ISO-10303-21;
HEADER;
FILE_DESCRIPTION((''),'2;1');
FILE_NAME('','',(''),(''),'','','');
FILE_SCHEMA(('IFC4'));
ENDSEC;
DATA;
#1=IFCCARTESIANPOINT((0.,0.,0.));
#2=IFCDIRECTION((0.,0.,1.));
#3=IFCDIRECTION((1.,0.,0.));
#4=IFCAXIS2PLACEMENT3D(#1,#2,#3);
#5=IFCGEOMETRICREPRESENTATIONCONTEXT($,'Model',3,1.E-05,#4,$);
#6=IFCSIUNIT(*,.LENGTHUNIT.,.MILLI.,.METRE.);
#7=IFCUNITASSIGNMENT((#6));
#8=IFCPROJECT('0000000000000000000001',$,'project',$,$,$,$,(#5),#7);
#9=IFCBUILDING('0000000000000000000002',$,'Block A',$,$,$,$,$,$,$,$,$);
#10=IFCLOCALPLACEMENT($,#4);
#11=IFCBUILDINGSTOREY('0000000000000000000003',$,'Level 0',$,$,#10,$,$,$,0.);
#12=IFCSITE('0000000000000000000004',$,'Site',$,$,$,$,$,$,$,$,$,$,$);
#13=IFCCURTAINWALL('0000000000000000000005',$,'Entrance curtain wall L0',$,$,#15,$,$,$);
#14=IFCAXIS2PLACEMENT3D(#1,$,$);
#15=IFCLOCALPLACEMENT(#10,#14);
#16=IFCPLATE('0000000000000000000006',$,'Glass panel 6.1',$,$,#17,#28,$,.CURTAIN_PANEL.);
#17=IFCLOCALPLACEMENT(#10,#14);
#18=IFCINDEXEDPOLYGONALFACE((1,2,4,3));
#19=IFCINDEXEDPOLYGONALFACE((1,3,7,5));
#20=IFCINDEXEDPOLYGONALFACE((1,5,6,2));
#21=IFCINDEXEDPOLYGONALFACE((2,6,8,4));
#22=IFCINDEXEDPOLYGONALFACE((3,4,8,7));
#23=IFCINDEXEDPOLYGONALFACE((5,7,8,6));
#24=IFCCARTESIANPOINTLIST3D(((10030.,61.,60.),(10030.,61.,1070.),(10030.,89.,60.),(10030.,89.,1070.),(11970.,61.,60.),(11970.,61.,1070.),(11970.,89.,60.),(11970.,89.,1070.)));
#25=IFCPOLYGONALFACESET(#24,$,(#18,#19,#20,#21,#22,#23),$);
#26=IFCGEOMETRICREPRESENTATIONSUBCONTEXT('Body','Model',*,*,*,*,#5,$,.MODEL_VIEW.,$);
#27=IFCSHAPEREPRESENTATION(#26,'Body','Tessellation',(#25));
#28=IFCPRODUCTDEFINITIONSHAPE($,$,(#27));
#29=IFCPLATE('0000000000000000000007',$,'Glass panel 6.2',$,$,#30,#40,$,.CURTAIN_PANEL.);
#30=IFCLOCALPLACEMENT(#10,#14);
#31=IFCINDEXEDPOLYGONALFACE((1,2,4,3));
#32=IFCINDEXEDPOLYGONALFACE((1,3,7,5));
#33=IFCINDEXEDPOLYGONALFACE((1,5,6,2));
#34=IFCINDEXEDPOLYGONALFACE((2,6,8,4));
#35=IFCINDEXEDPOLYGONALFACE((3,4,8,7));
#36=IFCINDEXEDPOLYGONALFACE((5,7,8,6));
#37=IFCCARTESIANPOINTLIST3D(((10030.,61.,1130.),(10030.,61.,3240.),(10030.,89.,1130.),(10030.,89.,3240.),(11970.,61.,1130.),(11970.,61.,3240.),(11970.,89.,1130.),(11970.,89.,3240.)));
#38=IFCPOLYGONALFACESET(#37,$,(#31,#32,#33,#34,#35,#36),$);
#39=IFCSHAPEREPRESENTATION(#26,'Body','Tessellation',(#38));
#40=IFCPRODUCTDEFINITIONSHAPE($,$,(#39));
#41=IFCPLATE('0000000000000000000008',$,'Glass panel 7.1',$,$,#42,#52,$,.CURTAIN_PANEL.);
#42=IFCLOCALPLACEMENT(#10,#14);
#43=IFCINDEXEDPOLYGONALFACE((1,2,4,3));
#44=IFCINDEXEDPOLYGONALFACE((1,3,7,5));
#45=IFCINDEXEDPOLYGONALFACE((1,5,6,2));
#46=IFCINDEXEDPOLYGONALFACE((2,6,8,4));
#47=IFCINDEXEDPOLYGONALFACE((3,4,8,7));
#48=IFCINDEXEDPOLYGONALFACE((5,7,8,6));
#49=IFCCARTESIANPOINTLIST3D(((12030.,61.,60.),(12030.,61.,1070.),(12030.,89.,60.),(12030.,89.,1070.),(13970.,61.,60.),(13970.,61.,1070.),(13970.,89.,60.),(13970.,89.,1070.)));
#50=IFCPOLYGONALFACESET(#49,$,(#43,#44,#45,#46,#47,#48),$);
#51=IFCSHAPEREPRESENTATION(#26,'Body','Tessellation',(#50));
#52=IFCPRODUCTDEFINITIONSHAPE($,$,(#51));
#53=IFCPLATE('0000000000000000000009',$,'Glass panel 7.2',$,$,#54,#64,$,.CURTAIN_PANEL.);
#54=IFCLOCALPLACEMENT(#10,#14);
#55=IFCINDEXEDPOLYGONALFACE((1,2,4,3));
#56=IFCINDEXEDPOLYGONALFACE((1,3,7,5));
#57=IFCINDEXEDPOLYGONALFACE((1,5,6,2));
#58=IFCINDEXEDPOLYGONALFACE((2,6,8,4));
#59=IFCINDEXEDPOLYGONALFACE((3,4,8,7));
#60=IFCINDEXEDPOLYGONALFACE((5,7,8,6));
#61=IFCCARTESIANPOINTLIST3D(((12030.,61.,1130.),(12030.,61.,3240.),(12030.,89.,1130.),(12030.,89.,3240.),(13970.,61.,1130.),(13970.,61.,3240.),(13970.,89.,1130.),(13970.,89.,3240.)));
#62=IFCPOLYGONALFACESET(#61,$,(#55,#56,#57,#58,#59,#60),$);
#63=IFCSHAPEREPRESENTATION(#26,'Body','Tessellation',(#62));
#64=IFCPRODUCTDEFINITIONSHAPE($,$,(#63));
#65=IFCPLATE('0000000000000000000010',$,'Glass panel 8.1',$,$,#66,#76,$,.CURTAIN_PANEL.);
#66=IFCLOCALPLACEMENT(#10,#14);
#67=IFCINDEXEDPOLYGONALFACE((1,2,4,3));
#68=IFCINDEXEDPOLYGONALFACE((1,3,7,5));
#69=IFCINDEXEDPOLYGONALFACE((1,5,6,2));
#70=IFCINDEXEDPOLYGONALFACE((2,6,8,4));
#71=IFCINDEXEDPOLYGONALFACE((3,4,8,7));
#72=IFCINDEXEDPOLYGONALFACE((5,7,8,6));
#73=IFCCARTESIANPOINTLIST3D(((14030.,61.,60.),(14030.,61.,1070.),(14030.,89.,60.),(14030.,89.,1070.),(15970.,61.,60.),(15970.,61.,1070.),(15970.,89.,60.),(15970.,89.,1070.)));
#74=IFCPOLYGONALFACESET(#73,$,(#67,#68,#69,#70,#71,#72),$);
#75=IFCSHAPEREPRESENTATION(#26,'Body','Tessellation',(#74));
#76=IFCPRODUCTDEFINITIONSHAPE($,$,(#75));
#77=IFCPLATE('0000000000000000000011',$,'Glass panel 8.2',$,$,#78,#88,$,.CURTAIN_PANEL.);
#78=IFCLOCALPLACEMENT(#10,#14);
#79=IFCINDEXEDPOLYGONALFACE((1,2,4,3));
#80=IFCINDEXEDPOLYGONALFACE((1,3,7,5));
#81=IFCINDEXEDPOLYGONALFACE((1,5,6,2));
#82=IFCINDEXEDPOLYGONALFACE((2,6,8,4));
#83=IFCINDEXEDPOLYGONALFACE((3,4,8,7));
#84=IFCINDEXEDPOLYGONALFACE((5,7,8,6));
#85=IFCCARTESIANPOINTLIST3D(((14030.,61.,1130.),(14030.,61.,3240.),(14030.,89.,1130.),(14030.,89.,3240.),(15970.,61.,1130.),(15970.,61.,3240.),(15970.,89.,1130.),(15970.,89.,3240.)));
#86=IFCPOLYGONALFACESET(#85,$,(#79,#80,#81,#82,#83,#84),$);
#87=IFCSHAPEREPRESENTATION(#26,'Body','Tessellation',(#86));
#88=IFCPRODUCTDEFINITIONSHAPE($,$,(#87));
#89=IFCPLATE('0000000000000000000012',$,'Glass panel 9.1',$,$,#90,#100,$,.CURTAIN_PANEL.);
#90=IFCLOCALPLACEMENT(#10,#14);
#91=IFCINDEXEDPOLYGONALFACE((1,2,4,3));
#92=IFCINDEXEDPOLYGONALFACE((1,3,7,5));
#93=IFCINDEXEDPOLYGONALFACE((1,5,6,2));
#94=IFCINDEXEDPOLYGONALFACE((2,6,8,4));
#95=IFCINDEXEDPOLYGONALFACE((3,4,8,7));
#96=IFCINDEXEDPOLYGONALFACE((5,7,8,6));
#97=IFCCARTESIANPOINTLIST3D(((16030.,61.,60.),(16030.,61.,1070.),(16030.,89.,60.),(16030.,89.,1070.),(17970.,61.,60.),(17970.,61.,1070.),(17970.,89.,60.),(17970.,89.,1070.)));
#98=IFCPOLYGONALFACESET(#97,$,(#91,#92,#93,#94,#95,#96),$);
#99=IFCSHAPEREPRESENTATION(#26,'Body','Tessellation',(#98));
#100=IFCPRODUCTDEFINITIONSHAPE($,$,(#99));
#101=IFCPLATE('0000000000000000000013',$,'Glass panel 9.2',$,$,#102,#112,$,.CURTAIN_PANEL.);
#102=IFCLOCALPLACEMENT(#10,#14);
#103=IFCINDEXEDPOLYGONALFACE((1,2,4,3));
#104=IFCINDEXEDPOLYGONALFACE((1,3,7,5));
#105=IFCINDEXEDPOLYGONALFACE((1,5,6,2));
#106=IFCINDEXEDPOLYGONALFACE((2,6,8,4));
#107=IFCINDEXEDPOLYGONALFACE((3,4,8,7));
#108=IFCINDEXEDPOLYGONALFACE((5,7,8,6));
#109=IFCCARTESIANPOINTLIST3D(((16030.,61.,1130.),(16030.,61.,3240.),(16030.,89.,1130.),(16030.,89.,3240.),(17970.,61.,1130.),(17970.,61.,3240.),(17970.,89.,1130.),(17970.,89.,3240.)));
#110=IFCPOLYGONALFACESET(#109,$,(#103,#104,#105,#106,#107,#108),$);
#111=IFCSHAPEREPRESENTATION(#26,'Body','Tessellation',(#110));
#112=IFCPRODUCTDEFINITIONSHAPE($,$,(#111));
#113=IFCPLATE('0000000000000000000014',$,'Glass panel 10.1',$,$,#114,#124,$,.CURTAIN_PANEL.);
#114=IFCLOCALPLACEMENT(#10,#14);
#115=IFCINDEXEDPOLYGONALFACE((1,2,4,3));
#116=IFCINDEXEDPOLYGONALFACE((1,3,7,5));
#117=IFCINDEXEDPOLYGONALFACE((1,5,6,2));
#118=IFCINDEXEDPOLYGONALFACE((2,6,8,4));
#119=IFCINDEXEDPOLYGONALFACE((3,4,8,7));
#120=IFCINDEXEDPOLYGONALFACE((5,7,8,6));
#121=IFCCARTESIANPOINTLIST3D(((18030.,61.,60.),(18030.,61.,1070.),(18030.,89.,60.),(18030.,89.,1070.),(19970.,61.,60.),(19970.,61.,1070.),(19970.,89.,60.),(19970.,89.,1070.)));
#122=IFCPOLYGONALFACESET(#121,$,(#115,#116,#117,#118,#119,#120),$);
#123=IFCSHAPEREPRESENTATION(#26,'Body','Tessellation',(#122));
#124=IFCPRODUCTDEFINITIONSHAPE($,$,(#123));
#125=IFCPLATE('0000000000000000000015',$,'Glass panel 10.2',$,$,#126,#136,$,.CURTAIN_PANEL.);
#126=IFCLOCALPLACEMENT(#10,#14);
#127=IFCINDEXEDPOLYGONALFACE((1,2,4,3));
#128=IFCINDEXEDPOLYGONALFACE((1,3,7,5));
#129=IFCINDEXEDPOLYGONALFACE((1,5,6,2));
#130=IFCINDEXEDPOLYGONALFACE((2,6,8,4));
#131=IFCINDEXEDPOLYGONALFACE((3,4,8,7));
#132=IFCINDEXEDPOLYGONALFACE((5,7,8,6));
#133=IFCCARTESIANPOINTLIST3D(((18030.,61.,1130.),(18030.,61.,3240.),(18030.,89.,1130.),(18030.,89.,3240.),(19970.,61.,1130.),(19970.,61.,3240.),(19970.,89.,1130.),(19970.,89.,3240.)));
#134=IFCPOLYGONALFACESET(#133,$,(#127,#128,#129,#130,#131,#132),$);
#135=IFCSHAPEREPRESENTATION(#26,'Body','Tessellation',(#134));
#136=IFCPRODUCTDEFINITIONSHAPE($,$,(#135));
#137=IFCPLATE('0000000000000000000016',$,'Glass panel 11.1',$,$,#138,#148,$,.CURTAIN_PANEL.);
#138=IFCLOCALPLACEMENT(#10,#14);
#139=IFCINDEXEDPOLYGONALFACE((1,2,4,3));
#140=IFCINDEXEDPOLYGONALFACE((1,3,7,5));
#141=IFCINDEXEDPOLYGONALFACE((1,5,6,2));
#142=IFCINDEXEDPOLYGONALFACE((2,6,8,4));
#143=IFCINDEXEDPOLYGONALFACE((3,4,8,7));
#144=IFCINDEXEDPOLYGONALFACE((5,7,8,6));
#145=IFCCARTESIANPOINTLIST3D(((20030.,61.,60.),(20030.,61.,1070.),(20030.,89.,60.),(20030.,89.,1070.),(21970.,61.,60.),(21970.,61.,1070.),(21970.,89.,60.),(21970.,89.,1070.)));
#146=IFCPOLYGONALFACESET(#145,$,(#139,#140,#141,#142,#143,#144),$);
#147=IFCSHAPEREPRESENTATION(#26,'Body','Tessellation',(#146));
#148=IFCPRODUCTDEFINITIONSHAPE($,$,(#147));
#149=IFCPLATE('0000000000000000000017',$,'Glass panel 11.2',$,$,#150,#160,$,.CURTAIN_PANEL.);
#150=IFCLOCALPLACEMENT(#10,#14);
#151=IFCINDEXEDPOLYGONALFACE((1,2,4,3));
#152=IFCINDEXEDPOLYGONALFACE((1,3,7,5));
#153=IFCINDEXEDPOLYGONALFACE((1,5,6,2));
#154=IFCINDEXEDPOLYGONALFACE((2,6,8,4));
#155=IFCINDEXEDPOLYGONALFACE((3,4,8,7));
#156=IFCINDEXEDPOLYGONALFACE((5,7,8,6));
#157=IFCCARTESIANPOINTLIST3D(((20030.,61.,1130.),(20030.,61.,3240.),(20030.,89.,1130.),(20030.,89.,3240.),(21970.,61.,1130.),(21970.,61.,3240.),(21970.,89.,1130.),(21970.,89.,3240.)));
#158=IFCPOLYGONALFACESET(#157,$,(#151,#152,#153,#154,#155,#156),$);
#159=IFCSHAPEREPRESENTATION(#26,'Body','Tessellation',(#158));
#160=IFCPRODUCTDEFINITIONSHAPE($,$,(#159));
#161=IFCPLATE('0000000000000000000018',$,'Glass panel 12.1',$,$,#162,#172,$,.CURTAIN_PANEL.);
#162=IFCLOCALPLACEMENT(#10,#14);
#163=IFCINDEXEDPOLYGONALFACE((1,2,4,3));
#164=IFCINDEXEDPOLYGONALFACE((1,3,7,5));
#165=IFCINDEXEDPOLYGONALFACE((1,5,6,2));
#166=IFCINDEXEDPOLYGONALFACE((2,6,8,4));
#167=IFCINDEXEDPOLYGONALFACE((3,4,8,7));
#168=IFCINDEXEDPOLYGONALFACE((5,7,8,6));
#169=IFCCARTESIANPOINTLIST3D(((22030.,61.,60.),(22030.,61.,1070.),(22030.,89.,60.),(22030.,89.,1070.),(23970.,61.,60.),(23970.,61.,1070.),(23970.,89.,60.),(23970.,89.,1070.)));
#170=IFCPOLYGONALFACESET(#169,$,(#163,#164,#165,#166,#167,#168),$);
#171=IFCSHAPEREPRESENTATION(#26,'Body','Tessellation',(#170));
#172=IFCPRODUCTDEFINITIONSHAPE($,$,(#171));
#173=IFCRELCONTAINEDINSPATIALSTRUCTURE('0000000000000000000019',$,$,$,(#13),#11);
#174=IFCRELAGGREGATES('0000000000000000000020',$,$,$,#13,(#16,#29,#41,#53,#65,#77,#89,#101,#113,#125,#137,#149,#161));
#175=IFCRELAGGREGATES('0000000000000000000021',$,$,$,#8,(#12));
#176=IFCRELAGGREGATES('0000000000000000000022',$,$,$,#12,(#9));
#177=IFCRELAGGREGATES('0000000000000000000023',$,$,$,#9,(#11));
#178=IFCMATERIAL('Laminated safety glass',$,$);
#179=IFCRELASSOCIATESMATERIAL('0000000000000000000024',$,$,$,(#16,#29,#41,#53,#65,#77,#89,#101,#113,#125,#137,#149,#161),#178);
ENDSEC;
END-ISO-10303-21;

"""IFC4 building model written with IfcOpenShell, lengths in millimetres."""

from ifc_helpers import new_model, si_unit, frame, origin_with_axes, place, context, subcontext, project, spatial, indexed_curve, outline, extrude, material, element, aggregate, save


model = new_model("IFC4")

# Units and contexts
model_context = context("Model", 3, precision=1e-05, world=origin_with_axes())
body_context = subcontext(model_context, "Body", "Model", "MODEL_VIEW")
ifc_project = project(units=[si_unit("LENGTHUNIT", "METRE", prefix="MILLI")], contexts=[model_context])

# Site, building, storey
site = spatial("IfcSite", under=ifc_project, Name="Site")
building = spatial("IfcBuilding", under=site, Name="Block A")
storey_placement = place(None, origin_with_axes())
storey = spatial("IfcBuildingStorey", under=building, at=storey_placement, Name="Level 0", Elevation=0.0)

# Curtain wall, plates
curtain_wall_placement = place(storey_placement, origin_with_axes())
curtain_wall = element("IfcCurtainWall", 1, at=curtain_wall_placement, inside=storey, Name="Entrance curtain wall L0")
ifc_material_1 = material(Name="Laminated safety glass")
plate_1_placement = place(curtain_wall_placement, frame((10030.0, 61.0, 60.0), z_axis=(0.0, 0.0, 1.0), x_axis=(1.0, 0.0, 0.0)))
plate_1 = element("IfcPlate", 2, at=plate_1_placement, material=ifc_material_1, Name="Glass panel 6.1", PredefinedType="CURTAIN_PANEL", context=body_context, shape_type="SweptSolid", body=[
    extrude(outline(indexed_curve([(0.0, 0.0), (0.0, 28.0), (1940.0, 28.0), (1940.0, 0.0), (0.0, 0.0)], self_intersect=False)), origin_with_axes(), (0.0, 0.0, 1.0), 1010.0),
])
plate_2_placement = place(curtain_wall_placement, frame((10030.0, 61.0, 1130.0), z_axis=(0.0, 0.0, 1.0), x_axis=(1.0, 0.0, 0.0)))
plate_2 = element("IfcPlate", 3, at=plate_2_placement, material=ifc_material_1, Name="Glass panel 6.2", PredefinedType="CURTAIN_PANEL", context=body_context, shape_type="SweptSolid", body=[
    extrude(outline(indexed_curve([(0.0, 0.0), (0.0, 28.0), (1940.0, 28.0), (1940.0, 0.0), (0.0, 0.0)], self_intersect=False)), origin_with_axes(), (0.0, 0.0, 1.0), 2110.0),
])
plate_3_placement = place(curtain_wall_placement, frame((12030.0, 61.0, 60.0), z_axis=(0.0, 0.0, 1.0), x_axis=(1.0, 0.0, 0.0)))
plate_3 = element("IfcPlate", 4, at=plate_3_placement, material=ifc_material_1, Name="Glass panel 7.1", PredefinedType="CURTAIN_PANEL", context=body_context, shape_type="SweptSolid", body=[
    extrude(outline(indexed_curve([(0.0, 0.0), (0.0, 28.0), (1940.0, 28.0), (1940.0, 0.0), (0.0, 0.0)], self_intersect=False)), origin_with_axes(), (0.0, 0.0, 1.0), 1010.0),
])
plate_4_placement = place(curtain_wall_placement, frame((12030.0, 61.0, 1130.0), z_axis=(0.0, 0.0, 1.0), x_axis=(1.0, 0.0, 0.0)))
plate_4 = element("IfcPlate", 5, at=plate_4_placement, material=ifc_material_1, Name="Glass panel 7.2", PredefinedType="CURTAIN_PANEL", context=body_context, shape_type="SweptSolid", body=[
    extrude(outline(indexed_curve([(0.0, 0.0), (0.0, 28.0), (1940.0, 28.0), (1940.0, 0.0), (0.0, 0.0)], self_intersect=False)), origin_with_axes(), (0.0, 0.0, 1.0), 2110.0),
])
plate_5_placement = place(curtain_wall_placement, frame((14030.0, 61.0, 60.0), z_axis=(0.0, 0.0, 1.0), x_axis=(1.0, 0.0, 0.0)))
plate_5 = element("IfcPlate", 6, at=plate_5_placement, material=ifc_material_1, Name="Glass panel 8.1", PredefinedType="CURTAIN_PANEL", context=body_context, shape_type="SweptSolid", body=[
    extrude(outline(indexed_curve([(0.0, 0.0), (0.0, 28.0), (1940.0, 28.0), (1940.0, 0.0), (0.0, 0.0)], self_intersect=False)), origin_with_axes(), (0.0, 0.0, 1.0), 1010.0),
])
plate_6_placement = place(curtain_wall_placement, frame((14030.0, 61.0, 1130.0), z_axis=(0.0, 0.0, 1.0), x_axis=(1.0, 0.0, 0.0)))
plate_6 = element("IfcPlate", 7, at=plate_6_placement, material=ifc_material_1, Name="Glass panel 8.2", PredefinedType="CURTAIN_PANEL", context=body_context, shape_type="SweptSolid", body=[
    extrude(outline(indexed_curve([(0.0, 0.0), (0.0, 28.0), (1940.0, 28.0), (1940.0, 0.0), (0.0, 0.0)], self_intersect=False)), origin_with_axes(), (0.0, 0.0, 1.0), 2110.0),
])
plate_7_placement = place(curtain_wall_placement, frame((16030.0, 61.0, 60.0), z_axis=(0.0, 0.0, 1.0), x_axis=(1.0, 0.0, 0.0)))
plate_7 = element("IfcPlate", 8, at=plate_7_placement, material=ifc_material_1, Name="Glass panel 9.1", PredefinedType="CURTAIN_PANEL", context=body_context, shape_type="SweptSolid", body=[
    extrude(outline(indexed_curve([(0.0, 0.0), (0.0, 28.0), (1940.0, 28.0), (1940.0, 0.0), (0.0, 0.0)], self_intersect=False)), origin_with_axes(), (0.0, 0.0, 1.0), 1010.0),
])
plate_8_placement = place(curtain_wall_placement, frame((16030.0, 61.0, 1130.0), z_axis=(0.0, 0.0, 1.0), x_axis=(1.0, 0.0, 0.0)))
plate_8 = element("IfcPlate", 9, at=plate_8_placement, material=ifc_material_1, Name="Glass panel 9.2", PredefinedType="CURTAIN_PANEL", context=body_context, shape_type="SweptSolid", body=[
    extrude(outline(indexed_curve([(0.0, 0.0), (0.0, 28.0), (1940.0, 28.0), (1940.0, 0.0), (0.0, 0.0)], self_intersect=False)), origin_with_axes(), (0.0, 0.0, 1.0), 2110.0),
])
plate_9_placement = place(curtain_wall_placement, frame((18030.0, 61.0, 60.0), z_axis=(0.0, 0.0, 1.0), x_axis=(1.0, 0.0, 0.0)))
plate_9 = element("IfcPlate", 10, at=plate_9_placement, material=ifc_material_1, Name="Glass panel 10.1", PredefinedType="CURTAIN_PANEL", context=body_context, shape_type="SweptSolid", body=[
    extrude(outline(indexed_curve([(0.0, 0.0), (0.0, 28.0), (1940.0, 28.0), (1940.0, 0.0), (0.0, 0.0)], self_intersect=False)), origin_with_axes(), (0.0, 0.0, 1.0), 1010.0),
])
plate_10_placement = place(curtain_wall_placement, frame((18030.0, 61.0, 1130.0), z_axis=(0.0, 0.0, 1.0), x_axis=(1.0, 0.0, 0.0)))
plate_10 = element("IfcPlate", 11, at=plate_10_placement, material=ifc_material_1, Name="Glass panel 10.2", PredefinedType="CURTAIN_PANEL", context=body_context, shape_type="SweptSolid", body=[
    extrude(outline(indexed_curve([(0.0, 0.0), (0.0, 28.0), (1940.0, 28.0), (1940.0, 0.0), (0.0, 0.0)], self_intersect=False)), origin_with_axes(), (0.0, 0.0, 1.0), 2110.0),
])
plate_11_placement = place(curtain_wall_placement, frame((20030.0, 61.0, 60.0), z_axis=(0.0, 0.0, 1.0), x_axis=(1.0, 0.0, 0.0)))
plate_11 = element("IfcPlate", 12, at=plate_11_placement, material=ifc_material_1, Name="Glass panel 11.1", PredefinedType="CURTAIN_PANEL", context=body_context, shape_type="SweptSolid", body=[
    extrude(outline(indexed_curve([(0.0, 0.0), (0.0, 28.0), (1940.0, 28.0), (1940.0, 0.0), (0.0, 0.0)], self_intersect=False)), origin_with_axes(), (0.0, 0.0, 1.0), 1010.0),
])
plate_12_placement = place(curtain_wall_placement, frame((20030.0, 61.0, 1130.0), z_axis=(0.0, 0.0, 1.0), x_axis=(1.0, 0.0, 0.0)))
plate_12 = element("IfcPlate", 13, at=plate_12_placement, material=ifc_material_1, Name="Glass panel 11.2", PredefinedType="CURTAIN_PANEL", context=body_context, shape_type="SweptSolid", body=[
    extrude(outline(indexed_curve([(0.0, 0.0), (0.0, 28.0), (1940.0, 28.0), (1940.0, 0.0), (0.0, 0.0)], self_intersect=False)), origin_with_axes(), (0.0, 0.0, 1.0), 2110.0),
])
plate_13_placement = place(curtain_wall_placement, frame((22030.0, 61.0, 60.0), z_axis=(0.0, 0.0, 1.0), x_axis=(1.0, 0.0, 0.0)))
plate_13 = element("IfcPlate", 14, at=plate_13_placement, material=ifc_material_1, Name="Glass panel 12.1", PredefinedType="CURTAIN_PANEL", context=body_context, shape_type="SweptSolid", body=[
    extrude(outline(indexed_curve([(0.0, 0.0), (0.0, 28.0), (1940.0, 28.0), (1940.0, 0.0), (0.0, 0.0)], self_intersect=False)), origin_with_axes(), (0.0, 0.0, 1.0), 1010.0),
])
aggregate(curtain_wall, [plate_1, plate_2, plate_3, plate_4, plate_5, plate_6, plate_7, plate_8, plate_9, plate_10, plate_11, plate_12, plate_13])

save(model, "model.ifc")
